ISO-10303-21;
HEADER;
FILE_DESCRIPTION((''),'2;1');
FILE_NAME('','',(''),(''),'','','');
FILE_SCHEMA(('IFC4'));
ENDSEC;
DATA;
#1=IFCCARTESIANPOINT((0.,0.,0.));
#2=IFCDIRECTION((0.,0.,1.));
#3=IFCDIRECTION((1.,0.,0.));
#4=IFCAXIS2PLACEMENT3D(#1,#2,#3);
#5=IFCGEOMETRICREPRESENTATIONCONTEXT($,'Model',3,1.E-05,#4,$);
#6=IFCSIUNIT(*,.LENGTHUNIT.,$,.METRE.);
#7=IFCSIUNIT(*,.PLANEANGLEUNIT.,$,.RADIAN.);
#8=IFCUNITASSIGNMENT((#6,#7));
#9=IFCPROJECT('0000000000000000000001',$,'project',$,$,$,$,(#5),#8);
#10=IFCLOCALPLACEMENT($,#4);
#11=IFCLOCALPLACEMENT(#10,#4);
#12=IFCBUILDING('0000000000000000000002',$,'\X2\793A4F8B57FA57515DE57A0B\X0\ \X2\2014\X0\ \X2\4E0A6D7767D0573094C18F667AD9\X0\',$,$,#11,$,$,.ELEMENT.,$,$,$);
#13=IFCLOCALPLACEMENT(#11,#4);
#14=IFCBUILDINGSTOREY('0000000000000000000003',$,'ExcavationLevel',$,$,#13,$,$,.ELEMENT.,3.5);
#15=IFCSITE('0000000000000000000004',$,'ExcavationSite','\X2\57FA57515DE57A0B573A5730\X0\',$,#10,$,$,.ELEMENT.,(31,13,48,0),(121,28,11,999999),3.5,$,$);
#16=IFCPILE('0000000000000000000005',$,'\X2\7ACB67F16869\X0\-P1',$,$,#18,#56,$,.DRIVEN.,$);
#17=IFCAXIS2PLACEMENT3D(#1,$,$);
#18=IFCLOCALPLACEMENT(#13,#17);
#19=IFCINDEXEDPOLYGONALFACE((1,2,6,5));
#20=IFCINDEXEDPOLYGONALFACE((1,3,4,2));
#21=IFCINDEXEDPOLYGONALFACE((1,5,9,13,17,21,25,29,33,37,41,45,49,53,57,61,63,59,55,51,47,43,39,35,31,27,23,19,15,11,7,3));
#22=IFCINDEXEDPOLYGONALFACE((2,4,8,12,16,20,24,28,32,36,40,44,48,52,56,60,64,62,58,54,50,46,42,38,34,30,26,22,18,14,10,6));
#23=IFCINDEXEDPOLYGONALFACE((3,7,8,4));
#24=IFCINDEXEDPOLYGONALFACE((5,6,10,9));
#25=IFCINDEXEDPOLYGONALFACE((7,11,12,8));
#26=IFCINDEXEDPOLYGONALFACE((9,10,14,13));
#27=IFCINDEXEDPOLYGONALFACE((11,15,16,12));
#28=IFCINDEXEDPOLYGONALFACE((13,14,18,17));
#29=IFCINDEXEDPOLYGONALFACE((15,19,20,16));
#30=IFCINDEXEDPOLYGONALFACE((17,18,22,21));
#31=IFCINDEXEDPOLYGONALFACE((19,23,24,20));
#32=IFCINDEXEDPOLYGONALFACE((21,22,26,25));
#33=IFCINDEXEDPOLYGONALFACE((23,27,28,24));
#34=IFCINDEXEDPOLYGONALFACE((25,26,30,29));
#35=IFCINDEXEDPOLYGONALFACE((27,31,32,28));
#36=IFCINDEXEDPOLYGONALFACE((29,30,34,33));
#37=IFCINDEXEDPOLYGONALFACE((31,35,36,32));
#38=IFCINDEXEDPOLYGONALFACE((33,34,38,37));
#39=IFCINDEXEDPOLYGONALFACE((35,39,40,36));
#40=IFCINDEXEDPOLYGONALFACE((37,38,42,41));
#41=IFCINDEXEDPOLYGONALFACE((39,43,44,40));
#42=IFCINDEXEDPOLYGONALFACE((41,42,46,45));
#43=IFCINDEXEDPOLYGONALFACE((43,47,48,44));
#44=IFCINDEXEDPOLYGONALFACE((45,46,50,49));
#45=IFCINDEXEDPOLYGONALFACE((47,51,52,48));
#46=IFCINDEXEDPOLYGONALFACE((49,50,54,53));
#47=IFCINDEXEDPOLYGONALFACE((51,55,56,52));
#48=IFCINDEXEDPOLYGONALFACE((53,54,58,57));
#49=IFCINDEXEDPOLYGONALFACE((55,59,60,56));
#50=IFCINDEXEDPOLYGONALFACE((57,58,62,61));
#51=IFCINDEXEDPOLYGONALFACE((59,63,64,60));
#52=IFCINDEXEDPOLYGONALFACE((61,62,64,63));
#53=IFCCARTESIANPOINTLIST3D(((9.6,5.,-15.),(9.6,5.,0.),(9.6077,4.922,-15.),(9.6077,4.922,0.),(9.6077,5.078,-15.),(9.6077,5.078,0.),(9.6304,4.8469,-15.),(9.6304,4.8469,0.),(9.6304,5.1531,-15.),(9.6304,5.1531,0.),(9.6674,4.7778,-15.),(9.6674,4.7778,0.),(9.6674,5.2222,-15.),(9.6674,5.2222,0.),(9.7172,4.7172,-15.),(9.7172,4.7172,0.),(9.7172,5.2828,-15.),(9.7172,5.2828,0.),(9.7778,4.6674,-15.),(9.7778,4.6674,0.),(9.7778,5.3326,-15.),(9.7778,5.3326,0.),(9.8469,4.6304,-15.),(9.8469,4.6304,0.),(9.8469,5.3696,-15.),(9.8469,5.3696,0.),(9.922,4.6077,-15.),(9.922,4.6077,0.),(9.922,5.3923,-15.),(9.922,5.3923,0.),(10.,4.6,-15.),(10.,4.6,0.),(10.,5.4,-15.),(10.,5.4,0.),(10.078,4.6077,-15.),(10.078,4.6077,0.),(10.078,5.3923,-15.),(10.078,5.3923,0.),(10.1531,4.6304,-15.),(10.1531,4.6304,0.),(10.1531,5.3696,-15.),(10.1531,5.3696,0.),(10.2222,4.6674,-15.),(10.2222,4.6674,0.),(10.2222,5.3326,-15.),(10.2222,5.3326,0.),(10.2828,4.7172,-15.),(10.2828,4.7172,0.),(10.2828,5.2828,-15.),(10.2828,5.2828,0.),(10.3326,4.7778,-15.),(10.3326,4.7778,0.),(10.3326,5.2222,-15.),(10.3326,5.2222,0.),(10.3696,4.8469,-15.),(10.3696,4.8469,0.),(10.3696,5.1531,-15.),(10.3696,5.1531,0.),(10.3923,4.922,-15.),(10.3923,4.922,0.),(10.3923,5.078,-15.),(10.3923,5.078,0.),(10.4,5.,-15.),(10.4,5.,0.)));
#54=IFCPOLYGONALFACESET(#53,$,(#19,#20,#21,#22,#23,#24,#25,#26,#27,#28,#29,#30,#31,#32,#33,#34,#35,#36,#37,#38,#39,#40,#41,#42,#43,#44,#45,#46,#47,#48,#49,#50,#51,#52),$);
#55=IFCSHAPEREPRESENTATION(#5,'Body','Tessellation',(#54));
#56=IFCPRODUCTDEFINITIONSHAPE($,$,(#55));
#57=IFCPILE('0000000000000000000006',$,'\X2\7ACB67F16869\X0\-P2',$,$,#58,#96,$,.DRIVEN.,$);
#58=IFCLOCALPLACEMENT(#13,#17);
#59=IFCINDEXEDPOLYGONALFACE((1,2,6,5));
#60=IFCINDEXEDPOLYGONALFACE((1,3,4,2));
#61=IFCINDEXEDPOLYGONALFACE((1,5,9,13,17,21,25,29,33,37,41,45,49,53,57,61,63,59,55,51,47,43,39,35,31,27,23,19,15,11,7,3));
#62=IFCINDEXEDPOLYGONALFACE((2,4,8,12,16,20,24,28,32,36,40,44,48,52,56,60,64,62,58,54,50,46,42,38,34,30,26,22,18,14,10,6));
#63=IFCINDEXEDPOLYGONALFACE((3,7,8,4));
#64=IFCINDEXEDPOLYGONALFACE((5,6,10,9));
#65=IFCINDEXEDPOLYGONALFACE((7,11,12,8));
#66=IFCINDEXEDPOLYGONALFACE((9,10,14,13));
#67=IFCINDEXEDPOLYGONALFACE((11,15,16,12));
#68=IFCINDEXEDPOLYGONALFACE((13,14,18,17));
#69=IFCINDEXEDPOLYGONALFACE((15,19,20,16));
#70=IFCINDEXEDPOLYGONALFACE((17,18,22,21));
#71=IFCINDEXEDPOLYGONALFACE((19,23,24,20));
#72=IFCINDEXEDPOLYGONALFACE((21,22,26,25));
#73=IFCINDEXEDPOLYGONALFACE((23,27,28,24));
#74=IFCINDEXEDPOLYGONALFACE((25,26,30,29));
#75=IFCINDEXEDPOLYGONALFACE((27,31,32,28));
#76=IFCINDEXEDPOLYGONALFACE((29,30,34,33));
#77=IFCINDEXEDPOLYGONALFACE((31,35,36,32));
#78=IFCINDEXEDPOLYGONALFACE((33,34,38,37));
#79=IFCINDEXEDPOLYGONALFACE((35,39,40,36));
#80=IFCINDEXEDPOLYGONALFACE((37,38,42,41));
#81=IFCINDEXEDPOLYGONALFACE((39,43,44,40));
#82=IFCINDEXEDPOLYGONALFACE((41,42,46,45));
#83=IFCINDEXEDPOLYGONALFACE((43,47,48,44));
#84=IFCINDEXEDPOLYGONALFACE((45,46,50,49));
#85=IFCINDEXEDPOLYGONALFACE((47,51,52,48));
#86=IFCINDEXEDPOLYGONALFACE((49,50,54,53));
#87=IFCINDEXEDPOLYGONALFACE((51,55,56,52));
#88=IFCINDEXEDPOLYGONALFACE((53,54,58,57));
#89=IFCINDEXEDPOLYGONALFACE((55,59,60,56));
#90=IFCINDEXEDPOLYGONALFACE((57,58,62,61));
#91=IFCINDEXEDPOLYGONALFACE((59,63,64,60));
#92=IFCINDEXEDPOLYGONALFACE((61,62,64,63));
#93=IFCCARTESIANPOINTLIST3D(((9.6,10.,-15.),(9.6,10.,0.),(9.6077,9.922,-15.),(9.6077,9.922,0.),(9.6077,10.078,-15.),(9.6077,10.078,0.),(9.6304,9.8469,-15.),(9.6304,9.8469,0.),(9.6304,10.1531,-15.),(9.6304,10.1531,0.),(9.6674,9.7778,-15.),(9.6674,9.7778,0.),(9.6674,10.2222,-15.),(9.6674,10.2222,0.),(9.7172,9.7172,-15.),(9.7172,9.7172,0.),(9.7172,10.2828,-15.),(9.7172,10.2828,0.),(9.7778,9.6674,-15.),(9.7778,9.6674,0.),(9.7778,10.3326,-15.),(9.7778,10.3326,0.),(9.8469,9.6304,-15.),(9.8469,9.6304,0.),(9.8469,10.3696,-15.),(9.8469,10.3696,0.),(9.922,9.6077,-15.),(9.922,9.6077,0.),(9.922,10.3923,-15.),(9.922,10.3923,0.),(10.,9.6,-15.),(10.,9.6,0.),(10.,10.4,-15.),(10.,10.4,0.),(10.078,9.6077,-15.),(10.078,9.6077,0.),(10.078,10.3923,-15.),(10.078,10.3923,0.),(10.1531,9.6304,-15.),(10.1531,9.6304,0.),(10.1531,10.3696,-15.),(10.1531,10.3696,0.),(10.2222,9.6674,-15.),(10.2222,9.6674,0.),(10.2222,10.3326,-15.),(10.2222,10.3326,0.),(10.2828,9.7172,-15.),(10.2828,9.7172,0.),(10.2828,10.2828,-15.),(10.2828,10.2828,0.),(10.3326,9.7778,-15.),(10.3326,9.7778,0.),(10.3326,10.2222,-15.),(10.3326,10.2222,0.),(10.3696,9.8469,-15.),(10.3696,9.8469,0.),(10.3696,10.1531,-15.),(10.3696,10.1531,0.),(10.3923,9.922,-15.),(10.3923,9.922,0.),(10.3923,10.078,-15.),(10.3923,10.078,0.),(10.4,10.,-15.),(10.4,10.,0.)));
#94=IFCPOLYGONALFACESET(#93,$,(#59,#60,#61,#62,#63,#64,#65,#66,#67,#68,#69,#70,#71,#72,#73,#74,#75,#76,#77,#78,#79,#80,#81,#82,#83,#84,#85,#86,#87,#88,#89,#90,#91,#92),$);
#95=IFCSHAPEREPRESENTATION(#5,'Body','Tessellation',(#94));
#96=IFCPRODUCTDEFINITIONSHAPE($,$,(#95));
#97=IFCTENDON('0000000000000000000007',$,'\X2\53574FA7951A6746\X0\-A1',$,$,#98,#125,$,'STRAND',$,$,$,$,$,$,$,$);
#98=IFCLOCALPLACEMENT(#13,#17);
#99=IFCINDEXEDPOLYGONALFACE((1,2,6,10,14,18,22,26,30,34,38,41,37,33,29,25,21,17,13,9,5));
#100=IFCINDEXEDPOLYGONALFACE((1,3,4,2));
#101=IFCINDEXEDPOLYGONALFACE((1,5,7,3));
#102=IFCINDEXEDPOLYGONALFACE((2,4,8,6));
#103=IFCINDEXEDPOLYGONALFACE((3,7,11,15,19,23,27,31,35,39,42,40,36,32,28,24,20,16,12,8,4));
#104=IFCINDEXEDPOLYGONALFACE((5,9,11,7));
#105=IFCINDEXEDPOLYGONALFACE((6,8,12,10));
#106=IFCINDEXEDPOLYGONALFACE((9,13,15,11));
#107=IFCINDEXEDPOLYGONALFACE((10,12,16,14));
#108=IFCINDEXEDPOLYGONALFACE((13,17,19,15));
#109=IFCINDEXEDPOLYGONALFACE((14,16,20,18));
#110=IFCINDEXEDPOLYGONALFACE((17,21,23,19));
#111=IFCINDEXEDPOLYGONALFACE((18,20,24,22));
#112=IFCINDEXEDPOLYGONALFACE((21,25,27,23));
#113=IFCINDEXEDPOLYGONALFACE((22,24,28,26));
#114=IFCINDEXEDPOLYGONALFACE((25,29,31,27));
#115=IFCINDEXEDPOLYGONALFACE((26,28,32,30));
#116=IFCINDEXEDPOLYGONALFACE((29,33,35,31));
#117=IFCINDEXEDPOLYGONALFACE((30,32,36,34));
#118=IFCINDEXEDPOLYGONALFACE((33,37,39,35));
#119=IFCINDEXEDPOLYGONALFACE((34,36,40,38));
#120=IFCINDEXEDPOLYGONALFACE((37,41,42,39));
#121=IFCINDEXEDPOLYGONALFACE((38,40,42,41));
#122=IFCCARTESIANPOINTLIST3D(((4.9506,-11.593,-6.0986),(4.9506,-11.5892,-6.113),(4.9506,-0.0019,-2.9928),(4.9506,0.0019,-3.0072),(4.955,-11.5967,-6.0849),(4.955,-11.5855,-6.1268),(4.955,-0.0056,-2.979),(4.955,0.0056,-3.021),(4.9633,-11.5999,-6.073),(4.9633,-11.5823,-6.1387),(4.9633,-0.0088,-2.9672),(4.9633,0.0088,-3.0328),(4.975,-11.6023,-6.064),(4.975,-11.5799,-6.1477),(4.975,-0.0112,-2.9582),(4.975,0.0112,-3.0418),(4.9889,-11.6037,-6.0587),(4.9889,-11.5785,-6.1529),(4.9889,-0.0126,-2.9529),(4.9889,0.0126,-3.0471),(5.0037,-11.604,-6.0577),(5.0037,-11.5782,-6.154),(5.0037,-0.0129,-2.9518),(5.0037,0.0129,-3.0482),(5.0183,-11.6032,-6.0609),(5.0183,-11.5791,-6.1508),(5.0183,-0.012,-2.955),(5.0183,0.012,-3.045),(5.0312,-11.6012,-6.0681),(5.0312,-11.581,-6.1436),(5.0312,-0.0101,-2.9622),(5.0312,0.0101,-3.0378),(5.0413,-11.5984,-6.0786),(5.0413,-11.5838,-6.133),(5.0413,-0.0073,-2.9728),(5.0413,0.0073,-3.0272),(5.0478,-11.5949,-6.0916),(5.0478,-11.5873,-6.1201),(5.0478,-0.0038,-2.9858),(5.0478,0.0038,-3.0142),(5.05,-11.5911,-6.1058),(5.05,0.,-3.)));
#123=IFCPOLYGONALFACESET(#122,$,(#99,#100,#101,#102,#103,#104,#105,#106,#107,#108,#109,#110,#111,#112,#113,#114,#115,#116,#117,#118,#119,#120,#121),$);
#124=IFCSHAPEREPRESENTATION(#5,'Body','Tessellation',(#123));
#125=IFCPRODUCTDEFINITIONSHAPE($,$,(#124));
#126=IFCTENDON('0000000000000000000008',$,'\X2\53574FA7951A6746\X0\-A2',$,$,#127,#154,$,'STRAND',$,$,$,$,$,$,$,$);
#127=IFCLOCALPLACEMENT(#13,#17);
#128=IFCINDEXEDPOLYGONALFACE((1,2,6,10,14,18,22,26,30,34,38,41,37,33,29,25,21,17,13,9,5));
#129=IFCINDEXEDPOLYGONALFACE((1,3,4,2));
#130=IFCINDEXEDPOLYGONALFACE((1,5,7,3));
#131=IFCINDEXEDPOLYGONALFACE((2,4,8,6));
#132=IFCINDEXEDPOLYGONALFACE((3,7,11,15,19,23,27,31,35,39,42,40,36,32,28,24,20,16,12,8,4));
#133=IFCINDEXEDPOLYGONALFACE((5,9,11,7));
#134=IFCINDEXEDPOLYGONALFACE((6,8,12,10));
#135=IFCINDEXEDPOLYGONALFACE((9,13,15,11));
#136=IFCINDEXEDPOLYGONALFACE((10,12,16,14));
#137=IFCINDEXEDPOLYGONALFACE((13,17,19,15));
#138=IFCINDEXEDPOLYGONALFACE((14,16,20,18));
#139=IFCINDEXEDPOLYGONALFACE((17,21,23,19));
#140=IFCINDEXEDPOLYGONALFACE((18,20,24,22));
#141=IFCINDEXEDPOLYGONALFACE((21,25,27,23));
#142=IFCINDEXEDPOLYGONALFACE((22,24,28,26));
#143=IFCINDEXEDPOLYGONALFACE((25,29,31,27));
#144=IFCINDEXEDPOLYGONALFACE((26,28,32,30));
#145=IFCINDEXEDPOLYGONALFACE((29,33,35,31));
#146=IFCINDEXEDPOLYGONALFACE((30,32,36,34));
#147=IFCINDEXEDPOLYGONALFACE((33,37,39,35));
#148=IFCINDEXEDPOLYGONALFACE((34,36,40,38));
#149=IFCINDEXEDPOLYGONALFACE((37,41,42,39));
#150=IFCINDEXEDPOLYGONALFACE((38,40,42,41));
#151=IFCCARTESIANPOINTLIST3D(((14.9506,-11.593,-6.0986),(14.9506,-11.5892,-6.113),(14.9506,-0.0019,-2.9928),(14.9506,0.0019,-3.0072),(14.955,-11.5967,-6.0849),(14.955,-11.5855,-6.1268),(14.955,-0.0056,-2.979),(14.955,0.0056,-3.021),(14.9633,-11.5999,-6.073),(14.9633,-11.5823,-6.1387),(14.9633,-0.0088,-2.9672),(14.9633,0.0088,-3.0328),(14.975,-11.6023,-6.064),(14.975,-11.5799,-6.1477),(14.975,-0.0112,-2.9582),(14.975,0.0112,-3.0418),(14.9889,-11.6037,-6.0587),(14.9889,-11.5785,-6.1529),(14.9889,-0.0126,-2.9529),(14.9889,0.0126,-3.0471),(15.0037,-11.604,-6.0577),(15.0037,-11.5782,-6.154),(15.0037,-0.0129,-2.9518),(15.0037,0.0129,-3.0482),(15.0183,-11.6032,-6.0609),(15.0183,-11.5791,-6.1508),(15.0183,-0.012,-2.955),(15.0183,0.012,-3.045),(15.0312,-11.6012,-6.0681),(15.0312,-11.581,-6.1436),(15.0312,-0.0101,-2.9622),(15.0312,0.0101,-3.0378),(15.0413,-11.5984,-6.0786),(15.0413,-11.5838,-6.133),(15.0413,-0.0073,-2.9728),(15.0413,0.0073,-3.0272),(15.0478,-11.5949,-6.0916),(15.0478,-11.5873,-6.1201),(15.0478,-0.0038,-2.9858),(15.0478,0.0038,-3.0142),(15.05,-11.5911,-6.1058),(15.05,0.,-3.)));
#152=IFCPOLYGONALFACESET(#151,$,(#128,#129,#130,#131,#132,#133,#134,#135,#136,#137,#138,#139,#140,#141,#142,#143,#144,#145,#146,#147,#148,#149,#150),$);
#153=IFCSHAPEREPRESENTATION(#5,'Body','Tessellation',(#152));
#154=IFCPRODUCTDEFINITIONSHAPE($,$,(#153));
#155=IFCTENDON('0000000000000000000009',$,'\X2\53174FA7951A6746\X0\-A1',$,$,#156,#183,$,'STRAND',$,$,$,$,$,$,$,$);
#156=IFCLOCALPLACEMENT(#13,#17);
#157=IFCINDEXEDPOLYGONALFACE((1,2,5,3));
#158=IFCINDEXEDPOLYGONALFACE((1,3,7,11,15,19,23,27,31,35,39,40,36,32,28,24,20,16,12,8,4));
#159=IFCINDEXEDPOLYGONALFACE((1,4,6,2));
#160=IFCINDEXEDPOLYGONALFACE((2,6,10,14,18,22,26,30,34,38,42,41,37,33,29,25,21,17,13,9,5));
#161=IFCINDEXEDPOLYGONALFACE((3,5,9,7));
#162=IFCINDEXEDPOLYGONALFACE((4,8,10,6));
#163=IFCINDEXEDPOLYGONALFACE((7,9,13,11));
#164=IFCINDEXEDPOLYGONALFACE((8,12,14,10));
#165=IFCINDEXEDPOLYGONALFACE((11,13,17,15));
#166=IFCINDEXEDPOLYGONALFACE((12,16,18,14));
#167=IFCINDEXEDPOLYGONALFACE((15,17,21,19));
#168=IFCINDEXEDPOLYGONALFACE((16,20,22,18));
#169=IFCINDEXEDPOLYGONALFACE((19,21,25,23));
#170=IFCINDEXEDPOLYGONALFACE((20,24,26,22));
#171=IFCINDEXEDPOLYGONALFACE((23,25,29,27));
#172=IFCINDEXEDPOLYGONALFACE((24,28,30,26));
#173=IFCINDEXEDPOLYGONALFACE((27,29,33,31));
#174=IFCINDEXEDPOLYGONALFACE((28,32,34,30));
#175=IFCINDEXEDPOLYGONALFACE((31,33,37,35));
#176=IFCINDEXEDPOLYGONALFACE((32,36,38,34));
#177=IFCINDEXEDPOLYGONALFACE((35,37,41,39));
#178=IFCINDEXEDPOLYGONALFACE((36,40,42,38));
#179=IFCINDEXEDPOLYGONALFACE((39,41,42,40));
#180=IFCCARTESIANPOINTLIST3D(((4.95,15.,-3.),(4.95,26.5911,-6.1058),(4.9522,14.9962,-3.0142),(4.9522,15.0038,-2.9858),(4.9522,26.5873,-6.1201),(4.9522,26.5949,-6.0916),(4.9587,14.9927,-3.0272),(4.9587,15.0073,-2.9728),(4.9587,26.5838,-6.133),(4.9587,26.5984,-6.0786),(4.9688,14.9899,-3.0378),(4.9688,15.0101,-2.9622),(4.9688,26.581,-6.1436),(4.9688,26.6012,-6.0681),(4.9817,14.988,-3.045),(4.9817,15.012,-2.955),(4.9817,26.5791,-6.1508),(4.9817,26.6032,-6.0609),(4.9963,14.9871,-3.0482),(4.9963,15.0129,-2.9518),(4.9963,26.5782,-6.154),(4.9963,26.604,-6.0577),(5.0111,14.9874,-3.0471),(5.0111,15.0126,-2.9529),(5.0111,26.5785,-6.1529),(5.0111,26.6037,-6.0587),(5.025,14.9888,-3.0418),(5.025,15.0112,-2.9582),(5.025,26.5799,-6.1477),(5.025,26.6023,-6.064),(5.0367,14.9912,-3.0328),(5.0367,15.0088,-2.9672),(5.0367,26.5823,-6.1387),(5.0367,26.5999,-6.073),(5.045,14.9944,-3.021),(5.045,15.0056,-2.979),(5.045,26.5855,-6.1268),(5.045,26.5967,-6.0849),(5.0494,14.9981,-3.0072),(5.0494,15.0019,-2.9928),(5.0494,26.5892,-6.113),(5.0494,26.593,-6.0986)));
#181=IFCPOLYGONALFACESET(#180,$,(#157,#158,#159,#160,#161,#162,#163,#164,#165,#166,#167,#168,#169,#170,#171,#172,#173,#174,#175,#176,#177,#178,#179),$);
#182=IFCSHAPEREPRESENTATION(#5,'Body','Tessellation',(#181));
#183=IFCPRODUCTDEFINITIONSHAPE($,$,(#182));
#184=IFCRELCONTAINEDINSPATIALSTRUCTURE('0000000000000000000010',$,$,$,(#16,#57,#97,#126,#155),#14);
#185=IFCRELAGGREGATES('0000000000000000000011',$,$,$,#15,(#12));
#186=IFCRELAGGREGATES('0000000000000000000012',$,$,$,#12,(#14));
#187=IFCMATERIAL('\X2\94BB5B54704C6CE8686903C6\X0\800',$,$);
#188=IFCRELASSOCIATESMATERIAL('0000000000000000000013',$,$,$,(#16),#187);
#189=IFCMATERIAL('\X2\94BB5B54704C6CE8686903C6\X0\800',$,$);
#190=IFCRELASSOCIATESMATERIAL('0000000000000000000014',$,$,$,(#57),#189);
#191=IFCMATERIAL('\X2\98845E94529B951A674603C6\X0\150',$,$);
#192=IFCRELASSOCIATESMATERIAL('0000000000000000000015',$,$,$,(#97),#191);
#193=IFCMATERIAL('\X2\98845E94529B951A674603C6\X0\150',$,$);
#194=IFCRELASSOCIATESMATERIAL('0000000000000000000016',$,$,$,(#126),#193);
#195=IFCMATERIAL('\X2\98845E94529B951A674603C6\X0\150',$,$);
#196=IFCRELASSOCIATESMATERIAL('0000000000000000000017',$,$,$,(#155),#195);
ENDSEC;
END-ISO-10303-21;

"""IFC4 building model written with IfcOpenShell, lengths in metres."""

from ifc_helpers import new_model, si_unit, frame, origin_with_axes, origin_2d, place, context, project, spatial, circle, extrude, material, element, save


model = new_model("IFC4")

# Units and contexts
model_context = context("Model", 3, precision=1e-05, world=origin_with_axes())
ifc_project = project(units=[si_unit("LENGTHUNIT", "METRE"), si_unit("PLANEANGLEUNIT", "RADIAN")], contexts=[model_context])

# Site, building, storey
site_placement = place(None, origin_with_axes())
site = spatial("IfcSite", at=site_placement, Name="ExcavationSite", Description="基坑工程场地", CompositionType="ELEMENT", RefLatitude=(31, 13, 48, 0), RefLongitude=(121, 28, 11, 999999), RefElevation=3.5)
building_placement = place(site_placement, origin_with_axes())
building = spatial("IfcBuilding", under=site, at=building_placement, Name="示例基坑工程 — 上海某地铁车站", CompositionType="ELEMENT")
storey_placement = place(building_placement, origin_with_axes())
storey = spatial("IfcBuildingStorey", under=building, at=storey_placement, Name="ExcavationLevel", CompositionType="ELEMENT", Elevation=3.5)

# Piles
ifc_material_1 = material(Name="钻孔灌注桩φ800")
pile_1_placement = place(site_placement, origin_with_axes())
element("IfcPile", 1, at=pile_1_placement, inside=storey, material=ifc_material_1, Name="立柱桩-P1", PredefinedType="DRIVEN", context=model_context, shape_type="SweptSolid", body=[
    extrude(circle(Radius=0.4, at=origin_2d()), frame((10.0, 5.0, 0.0), z_axis=(0.0, 0.0, -1.0), x_axis=(0.0, 1.0, 0.0)), (0.0, 0.0, 1.0), 15.0),
])
ifc_material_2 = material(Name="钻孔灌注桩φ800")
pile_2_placement = place(site_placement, origin_with_axes())
element("IfcPile", 2, at=pile_2_placement, inside=storey, material=ifc_material_2, Name="立柱桩-P2", PredefinedType="DRIVEN", context=model_context, shape_type="SweptSolid", body=[
    extrude(circle(Radius=0.4, at=origin_2d()), frame((10.0, 10.0, 0.0), z_axis=(0.0, 0.0, -1.0), x_axis=(0.0, 1.0, 0.0)), (0.0, 0.0, 1.0), 15.0),
])

# Tendons
ifc_material_3 = material(Name="预应力锚杆φ150")
tendon_1_placement = place(site_placement, origin_with_axes())
element("IfcTendon", 3, at=tendon_1_placement, inside=storey, material=ifc_material_3, Name="南侧锚杆-A1", SteelGrade="STRAND", context=model_context, shape_type="SweptSolid", body=[
    extrude(circle(Radius=0.05, at=origin_2d()), frame((5.0, 0.0, -3.0), z_axis=(0.0, -0.965926, -0.258819), x_axis=(1.0, 0.0, 0.0)), (0.0, 0.0, 1.0), 12.0),
])
ifc_material_4 = material(Name="预应力锚杆φ150")
tendon_2_placement = place(site_placement, origin_with_axes())
element("IfcTendon", 4, at=tendon_2_placement, inside=storey, material=ifc_material_4, Name="南侧锚杆-A2", SteelGrade="STRAND", context=model_context, shape_type="SweptSolid", body=[
    extrude(circle(Radius=0.05, at=origin_2d()), frame((15.0, 0.0, -3.0), z_axis=(0.0, -0.965926, -0.258819), x_axis=(1.0, 0.0, 0.0)), (0.0, 0.0, 1.0), 12.0),
])
ifc_material_5 = material(Name="预应力锚杆φ150")
tendon_3_placement = place(site_placement, origin_with_axes())
element("IfcTendon", 5, at=tendon_3_placement, inside=storey, material=ifc_material_5, Name="北侧锚杆-A1", SteelGrade="STRAND", context=model_context, shape_type="SweptSolid", body=[
    extrude(circle(Radius=0.05, at=origin_2d()), frame((5.0, 15.0, -3.0), z_axis=(0.0, 0.965926, -0.258819), x_axis=(-1.0, 0.0, 0.0)), (0.0, 0.0, 1.0), 12.0),
])

save(model, "model.ifc")
